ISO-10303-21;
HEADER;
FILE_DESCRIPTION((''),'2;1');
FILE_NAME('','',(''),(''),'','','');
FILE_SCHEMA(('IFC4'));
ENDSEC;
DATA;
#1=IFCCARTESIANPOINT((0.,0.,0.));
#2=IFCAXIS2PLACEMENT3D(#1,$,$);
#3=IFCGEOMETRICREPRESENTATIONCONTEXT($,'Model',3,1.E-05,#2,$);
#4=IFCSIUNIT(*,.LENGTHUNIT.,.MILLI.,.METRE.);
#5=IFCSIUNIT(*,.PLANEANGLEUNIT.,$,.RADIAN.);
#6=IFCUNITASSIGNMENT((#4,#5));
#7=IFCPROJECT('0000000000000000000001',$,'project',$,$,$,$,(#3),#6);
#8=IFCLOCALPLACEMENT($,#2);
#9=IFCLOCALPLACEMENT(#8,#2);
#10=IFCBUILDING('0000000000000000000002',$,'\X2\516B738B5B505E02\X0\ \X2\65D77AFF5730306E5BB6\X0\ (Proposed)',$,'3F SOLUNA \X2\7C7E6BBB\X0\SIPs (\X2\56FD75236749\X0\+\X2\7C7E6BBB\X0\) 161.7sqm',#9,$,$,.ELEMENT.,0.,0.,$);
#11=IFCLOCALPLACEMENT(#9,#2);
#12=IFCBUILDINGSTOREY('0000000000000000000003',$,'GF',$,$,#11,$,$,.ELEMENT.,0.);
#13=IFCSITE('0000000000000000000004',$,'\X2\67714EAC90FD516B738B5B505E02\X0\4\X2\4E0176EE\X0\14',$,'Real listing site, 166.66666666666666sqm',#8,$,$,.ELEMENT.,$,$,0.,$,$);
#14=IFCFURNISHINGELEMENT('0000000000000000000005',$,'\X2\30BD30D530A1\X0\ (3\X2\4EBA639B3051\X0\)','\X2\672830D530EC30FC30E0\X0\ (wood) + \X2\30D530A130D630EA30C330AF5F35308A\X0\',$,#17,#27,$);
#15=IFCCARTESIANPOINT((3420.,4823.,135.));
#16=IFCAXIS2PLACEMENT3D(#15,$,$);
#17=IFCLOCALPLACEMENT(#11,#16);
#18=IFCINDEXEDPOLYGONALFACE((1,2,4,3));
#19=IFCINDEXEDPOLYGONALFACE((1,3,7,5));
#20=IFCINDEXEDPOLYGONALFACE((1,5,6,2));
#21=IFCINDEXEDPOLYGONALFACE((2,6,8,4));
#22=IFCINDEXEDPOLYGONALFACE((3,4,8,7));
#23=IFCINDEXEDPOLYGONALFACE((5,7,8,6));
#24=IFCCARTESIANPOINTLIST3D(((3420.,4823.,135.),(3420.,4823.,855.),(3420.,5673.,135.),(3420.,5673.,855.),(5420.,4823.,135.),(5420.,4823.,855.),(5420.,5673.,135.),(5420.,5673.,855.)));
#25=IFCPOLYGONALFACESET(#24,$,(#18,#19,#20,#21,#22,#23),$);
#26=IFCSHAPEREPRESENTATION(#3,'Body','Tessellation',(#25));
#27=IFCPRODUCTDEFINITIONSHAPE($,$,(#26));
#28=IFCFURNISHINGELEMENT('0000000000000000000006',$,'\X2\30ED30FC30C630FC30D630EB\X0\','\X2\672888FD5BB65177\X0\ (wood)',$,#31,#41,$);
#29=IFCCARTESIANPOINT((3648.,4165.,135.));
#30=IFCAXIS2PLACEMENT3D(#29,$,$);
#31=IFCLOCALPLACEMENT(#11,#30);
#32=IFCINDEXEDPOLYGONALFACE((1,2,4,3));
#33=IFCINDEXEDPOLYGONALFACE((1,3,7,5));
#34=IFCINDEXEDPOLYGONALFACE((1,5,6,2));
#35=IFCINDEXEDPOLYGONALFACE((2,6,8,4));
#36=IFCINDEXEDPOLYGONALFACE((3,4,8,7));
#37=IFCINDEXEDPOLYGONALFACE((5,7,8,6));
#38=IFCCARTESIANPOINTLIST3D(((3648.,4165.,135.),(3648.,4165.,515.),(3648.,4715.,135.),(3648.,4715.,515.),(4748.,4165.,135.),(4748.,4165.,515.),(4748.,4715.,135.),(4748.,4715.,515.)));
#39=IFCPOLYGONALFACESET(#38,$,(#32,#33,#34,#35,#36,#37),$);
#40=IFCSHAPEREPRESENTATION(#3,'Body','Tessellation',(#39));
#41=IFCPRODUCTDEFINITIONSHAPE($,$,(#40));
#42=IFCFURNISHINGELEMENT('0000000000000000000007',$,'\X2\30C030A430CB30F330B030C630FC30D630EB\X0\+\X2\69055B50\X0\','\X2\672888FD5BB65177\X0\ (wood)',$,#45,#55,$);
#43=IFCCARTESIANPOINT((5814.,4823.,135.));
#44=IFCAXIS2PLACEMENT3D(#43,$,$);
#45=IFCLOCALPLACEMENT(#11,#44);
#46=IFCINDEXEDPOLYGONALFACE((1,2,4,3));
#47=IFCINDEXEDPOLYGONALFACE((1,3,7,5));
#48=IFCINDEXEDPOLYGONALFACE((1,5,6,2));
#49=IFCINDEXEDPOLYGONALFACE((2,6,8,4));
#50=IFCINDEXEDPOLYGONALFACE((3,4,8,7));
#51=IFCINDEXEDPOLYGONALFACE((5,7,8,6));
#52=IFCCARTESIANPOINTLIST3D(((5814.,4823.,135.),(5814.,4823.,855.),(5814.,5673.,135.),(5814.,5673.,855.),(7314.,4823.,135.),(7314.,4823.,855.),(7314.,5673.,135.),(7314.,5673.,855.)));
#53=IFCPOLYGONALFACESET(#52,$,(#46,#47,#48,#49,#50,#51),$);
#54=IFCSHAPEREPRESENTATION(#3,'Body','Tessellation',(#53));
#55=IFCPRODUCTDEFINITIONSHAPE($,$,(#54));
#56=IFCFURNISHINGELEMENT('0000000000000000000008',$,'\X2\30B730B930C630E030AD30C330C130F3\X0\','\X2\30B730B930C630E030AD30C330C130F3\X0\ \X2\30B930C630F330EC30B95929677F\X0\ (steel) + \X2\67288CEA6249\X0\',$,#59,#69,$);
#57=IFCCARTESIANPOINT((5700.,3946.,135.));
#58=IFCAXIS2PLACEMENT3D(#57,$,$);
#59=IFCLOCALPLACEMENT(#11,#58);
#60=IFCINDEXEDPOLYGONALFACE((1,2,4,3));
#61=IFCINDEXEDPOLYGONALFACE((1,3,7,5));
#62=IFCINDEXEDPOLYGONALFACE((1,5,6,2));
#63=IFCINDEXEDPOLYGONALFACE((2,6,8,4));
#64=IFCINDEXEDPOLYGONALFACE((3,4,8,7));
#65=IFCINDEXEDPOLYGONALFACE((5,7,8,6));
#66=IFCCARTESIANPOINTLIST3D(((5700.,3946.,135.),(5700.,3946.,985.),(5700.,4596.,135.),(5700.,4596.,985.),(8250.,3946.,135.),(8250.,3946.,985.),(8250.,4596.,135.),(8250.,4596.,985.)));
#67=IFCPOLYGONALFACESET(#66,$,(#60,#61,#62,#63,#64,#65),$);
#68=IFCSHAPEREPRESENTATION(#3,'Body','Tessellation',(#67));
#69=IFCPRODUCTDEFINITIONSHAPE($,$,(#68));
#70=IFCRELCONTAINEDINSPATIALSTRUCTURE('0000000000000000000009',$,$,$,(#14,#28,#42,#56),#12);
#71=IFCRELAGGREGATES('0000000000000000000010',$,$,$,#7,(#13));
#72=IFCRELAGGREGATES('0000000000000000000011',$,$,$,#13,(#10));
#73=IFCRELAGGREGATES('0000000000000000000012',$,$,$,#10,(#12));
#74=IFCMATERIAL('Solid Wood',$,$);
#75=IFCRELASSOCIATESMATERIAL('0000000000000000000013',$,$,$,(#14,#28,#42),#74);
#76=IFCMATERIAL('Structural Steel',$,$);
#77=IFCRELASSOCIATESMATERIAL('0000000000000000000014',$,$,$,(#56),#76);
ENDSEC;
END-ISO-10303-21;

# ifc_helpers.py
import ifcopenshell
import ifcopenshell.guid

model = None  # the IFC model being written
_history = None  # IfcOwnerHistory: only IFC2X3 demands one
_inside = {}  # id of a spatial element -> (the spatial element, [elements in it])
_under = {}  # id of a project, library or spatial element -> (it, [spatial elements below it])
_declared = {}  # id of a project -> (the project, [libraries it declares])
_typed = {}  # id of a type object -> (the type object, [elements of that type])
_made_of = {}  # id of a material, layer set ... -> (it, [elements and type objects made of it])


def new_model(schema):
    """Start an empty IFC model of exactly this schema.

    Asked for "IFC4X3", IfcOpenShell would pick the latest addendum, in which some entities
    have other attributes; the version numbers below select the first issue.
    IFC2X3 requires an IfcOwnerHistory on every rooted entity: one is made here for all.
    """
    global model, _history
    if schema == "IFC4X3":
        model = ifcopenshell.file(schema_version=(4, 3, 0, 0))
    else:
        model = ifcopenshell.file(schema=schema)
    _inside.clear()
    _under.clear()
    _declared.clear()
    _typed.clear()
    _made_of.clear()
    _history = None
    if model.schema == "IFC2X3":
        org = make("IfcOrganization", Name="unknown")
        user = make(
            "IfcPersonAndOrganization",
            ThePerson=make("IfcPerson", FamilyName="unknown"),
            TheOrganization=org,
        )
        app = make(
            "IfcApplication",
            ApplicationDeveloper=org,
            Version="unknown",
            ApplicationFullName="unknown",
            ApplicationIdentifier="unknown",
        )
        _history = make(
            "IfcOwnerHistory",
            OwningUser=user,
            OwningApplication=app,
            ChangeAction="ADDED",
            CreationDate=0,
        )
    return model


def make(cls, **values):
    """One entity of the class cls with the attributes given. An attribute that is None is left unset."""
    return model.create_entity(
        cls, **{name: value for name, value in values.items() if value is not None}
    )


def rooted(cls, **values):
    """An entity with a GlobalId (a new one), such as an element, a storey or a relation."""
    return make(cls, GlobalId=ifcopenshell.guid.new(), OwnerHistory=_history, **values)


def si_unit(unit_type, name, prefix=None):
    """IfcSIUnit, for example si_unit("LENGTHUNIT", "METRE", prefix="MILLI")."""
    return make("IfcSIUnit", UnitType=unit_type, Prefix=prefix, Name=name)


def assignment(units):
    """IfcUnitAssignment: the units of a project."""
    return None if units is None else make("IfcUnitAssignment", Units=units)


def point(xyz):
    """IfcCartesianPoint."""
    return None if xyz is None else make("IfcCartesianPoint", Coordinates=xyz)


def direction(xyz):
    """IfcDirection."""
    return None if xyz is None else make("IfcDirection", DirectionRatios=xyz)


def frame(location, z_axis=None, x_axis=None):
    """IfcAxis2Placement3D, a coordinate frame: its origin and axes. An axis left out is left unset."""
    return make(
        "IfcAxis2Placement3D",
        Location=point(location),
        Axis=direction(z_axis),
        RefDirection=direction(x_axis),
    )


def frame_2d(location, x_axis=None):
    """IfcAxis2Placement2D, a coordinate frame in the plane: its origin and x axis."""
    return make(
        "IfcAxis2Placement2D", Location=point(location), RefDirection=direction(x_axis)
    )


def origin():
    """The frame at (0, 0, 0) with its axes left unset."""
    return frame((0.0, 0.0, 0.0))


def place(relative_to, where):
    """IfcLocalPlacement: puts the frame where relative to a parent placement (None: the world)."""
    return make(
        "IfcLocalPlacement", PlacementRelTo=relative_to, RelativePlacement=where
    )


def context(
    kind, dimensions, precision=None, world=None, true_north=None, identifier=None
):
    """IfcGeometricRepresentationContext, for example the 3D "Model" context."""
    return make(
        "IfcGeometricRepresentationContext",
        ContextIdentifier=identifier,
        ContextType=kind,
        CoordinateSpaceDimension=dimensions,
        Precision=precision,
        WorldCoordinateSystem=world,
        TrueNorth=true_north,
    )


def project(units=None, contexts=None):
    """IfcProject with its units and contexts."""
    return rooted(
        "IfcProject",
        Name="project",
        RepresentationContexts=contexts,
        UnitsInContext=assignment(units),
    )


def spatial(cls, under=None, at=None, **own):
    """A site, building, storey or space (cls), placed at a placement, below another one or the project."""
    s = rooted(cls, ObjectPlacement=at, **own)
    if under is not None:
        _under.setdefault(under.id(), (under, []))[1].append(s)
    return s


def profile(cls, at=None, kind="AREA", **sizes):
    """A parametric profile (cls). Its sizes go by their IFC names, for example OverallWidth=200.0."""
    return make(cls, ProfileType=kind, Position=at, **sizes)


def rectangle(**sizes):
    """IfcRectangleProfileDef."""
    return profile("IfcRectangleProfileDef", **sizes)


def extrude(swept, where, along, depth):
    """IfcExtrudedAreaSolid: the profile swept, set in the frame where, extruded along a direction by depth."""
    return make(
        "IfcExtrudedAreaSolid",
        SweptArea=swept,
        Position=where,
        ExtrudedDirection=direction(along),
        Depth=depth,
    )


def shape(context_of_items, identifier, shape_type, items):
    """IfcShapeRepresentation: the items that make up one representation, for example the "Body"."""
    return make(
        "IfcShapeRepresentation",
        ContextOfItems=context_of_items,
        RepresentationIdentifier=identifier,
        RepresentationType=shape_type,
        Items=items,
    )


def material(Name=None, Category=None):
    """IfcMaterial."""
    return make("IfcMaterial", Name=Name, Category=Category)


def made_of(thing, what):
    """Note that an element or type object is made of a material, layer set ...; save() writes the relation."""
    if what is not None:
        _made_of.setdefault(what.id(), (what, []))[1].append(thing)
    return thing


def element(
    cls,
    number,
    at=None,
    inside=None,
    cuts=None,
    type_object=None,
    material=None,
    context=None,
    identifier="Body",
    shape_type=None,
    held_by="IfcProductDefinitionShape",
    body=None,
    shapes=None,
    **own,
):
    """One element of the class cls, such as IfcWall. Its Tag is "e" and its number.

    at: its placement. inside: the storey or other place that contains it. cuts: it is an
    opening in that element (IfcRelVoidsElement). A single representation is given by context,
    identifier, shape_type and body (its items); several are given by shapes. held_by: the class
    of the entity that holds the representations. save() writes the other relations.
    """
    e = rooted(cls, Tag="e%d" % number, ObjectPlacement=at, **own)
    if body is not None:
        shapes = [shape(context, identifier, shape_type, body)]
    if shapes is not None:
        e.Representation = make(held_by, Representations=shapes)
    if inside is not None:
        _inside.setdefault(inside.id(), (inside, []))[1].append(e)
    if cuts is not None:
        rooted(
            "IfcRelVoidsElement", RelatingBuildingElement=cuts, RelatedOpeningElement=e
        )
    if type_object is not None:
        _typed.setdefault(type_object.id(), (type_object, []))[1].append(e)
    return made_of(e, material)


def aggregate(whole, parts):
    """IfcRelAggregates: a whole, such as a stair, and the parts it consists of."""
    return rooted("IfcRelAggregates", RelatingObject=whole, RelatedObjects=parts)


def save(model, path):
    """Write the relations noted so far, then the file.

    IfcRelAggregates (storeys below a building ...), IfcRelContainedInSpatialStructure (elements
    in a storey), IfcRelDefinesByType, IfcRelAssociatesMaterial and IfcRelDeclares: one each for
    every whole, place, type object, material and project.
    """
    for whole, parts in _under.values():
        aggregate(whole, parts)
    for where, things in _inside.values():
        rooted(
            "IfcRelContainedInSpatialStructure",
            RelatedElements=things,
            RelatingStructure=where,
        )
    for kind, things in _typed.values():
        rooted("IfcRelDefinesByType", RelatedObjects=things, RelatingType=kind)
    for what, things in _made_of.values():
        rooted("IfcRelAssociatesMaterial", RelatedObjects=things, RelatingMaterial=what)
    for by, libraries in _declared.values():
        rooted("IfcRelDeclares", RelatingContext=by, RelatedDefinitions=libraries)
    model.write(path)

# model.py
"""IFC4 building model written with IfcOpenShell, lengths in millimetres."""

from ifc_helpers import new_model, si_unit, frame, frame_2d, origin, place, context, project, spatial, rectangle, extrude, material, element, save


model = new_model("IFC4")

# Units and contexts
model_context = context("Model", 3, precision=1e-05, world=origin())
ifc_project = project(units=[si_unit("LENGTHUNIT", "METRE", prefix="MILLI"), si_unit("PLANEANGLEUNIT", "RADIAN")], contexts=[model_context])

# Site, building, storey
site_placement = place(None, origin())
site = spatial("IfcSite", under=ifc_project, at=site_placement, Name="東京都八王子市4丁目14", ObjectType="Real listing site, 166.66666666666666sqm", CompositionType="ELEMENT", RefElevation=0.0)
building_placement = place(site_placement, origin())
building = spatial("IfcBuilding", under=site, at=building_placement, Name="八王子市 旗竿地の家 (Proposed)", ObjectType="3F SOLUNA 籾殻SIPs (国産杉+籾殻) 161.7sqm", CompositionType="ELEMENT", ElevationOfRefHeight=0.0, ElevationOfTerrain=0.0)
storey_placement = place(building_placement, origin())
storey = spatial("IfcBuildingStorey", under=building, at=storey_placement, Name="GF", CompositionType="ELEMENT", Elevation=0.0)

# Shared definitions
ifc_material_1 = material(Name="Solid Wood")

# Furnishing elements
furnishing_1_placement = place(storey_placement, frame((3420.0, 4823.0, 135.0)))
element("IfcFurnishingElement", 1, at=furnishing_1_placement, inside=storey, material=ifc_material_1, Name="ソファ (3人掛け)", Description="木フレーム (wood) + ファブリック張り", context=model_context, shape_type="SweptSolid", body=[
    extrude(rectangle(XDim=2000.0, YDim=850.0, at=frame_2d((1000.0, 425.0))), frame((3420.0, 4823.0, 135.0)), (0.0, 0.0, 1.0), 720.0),
])
furnishing_2_placement = place(storey_placement, frame((3648.0, 4165.0, 135.0)))
element("IfcFurnishingElement", 2, at=furnishing_2_placement, inside=storey, material=ifc_material_1, Name="ローテーブル", Description="木製家具 (wood)", context=model_context, shape_type="SweptSolid", body=[
    extrude(rectangle(XDim=1100.0, YDim=550.0, at=frame_2d((550.0, 275.0))), frame((3648.0, 4165.0, 135.0)), (0.0, 0.0, 1.0), 380.0),
])
furnishing_3_placement = place(storey_placement, frame((5814.0, 4823.0, 135.0)))
element("IfcFurnishingElement", 3, at=furnishing_3_placement, inside=storey, material=ifc_material_1, Name="ダイニングテーブル+椅子", Description="木製家具 (wood)", context=model_context, shape_type="SweptSolid", body=[
    extrude(rectangle(XDim=1500.0, YDim=850.0, at=frame_2d((750.0, 425.0))), frame((5814.0, 4823.0, 135.0)), (0.0, 0.0, 1.0), 720.0),
])
ifc_material_2 = material(Name="Structural Steel")
furnishing_4_placement = place(storey_placement, frame((5700.0, 3946.0, 135.0)))
element("IfcFurnishingElement", 4, at=furnishing_4_placement, inside=storey, material=ifc_material_2, Name="システムキッチン", Description="システムキッチン ステンレス天板 (steel) + 木質扉", context=model_context, shape_type="SweptSolid", body=[
    extrude(rectangle(XDim=2550.0, YDim=650.0, at=frame_2d((1275.0, 325.0))), frame((5700.0, 3946.0, 135.0)), (0.0, 0.0, 1.0), 850.0),
])

save(model, "model.ifc")
